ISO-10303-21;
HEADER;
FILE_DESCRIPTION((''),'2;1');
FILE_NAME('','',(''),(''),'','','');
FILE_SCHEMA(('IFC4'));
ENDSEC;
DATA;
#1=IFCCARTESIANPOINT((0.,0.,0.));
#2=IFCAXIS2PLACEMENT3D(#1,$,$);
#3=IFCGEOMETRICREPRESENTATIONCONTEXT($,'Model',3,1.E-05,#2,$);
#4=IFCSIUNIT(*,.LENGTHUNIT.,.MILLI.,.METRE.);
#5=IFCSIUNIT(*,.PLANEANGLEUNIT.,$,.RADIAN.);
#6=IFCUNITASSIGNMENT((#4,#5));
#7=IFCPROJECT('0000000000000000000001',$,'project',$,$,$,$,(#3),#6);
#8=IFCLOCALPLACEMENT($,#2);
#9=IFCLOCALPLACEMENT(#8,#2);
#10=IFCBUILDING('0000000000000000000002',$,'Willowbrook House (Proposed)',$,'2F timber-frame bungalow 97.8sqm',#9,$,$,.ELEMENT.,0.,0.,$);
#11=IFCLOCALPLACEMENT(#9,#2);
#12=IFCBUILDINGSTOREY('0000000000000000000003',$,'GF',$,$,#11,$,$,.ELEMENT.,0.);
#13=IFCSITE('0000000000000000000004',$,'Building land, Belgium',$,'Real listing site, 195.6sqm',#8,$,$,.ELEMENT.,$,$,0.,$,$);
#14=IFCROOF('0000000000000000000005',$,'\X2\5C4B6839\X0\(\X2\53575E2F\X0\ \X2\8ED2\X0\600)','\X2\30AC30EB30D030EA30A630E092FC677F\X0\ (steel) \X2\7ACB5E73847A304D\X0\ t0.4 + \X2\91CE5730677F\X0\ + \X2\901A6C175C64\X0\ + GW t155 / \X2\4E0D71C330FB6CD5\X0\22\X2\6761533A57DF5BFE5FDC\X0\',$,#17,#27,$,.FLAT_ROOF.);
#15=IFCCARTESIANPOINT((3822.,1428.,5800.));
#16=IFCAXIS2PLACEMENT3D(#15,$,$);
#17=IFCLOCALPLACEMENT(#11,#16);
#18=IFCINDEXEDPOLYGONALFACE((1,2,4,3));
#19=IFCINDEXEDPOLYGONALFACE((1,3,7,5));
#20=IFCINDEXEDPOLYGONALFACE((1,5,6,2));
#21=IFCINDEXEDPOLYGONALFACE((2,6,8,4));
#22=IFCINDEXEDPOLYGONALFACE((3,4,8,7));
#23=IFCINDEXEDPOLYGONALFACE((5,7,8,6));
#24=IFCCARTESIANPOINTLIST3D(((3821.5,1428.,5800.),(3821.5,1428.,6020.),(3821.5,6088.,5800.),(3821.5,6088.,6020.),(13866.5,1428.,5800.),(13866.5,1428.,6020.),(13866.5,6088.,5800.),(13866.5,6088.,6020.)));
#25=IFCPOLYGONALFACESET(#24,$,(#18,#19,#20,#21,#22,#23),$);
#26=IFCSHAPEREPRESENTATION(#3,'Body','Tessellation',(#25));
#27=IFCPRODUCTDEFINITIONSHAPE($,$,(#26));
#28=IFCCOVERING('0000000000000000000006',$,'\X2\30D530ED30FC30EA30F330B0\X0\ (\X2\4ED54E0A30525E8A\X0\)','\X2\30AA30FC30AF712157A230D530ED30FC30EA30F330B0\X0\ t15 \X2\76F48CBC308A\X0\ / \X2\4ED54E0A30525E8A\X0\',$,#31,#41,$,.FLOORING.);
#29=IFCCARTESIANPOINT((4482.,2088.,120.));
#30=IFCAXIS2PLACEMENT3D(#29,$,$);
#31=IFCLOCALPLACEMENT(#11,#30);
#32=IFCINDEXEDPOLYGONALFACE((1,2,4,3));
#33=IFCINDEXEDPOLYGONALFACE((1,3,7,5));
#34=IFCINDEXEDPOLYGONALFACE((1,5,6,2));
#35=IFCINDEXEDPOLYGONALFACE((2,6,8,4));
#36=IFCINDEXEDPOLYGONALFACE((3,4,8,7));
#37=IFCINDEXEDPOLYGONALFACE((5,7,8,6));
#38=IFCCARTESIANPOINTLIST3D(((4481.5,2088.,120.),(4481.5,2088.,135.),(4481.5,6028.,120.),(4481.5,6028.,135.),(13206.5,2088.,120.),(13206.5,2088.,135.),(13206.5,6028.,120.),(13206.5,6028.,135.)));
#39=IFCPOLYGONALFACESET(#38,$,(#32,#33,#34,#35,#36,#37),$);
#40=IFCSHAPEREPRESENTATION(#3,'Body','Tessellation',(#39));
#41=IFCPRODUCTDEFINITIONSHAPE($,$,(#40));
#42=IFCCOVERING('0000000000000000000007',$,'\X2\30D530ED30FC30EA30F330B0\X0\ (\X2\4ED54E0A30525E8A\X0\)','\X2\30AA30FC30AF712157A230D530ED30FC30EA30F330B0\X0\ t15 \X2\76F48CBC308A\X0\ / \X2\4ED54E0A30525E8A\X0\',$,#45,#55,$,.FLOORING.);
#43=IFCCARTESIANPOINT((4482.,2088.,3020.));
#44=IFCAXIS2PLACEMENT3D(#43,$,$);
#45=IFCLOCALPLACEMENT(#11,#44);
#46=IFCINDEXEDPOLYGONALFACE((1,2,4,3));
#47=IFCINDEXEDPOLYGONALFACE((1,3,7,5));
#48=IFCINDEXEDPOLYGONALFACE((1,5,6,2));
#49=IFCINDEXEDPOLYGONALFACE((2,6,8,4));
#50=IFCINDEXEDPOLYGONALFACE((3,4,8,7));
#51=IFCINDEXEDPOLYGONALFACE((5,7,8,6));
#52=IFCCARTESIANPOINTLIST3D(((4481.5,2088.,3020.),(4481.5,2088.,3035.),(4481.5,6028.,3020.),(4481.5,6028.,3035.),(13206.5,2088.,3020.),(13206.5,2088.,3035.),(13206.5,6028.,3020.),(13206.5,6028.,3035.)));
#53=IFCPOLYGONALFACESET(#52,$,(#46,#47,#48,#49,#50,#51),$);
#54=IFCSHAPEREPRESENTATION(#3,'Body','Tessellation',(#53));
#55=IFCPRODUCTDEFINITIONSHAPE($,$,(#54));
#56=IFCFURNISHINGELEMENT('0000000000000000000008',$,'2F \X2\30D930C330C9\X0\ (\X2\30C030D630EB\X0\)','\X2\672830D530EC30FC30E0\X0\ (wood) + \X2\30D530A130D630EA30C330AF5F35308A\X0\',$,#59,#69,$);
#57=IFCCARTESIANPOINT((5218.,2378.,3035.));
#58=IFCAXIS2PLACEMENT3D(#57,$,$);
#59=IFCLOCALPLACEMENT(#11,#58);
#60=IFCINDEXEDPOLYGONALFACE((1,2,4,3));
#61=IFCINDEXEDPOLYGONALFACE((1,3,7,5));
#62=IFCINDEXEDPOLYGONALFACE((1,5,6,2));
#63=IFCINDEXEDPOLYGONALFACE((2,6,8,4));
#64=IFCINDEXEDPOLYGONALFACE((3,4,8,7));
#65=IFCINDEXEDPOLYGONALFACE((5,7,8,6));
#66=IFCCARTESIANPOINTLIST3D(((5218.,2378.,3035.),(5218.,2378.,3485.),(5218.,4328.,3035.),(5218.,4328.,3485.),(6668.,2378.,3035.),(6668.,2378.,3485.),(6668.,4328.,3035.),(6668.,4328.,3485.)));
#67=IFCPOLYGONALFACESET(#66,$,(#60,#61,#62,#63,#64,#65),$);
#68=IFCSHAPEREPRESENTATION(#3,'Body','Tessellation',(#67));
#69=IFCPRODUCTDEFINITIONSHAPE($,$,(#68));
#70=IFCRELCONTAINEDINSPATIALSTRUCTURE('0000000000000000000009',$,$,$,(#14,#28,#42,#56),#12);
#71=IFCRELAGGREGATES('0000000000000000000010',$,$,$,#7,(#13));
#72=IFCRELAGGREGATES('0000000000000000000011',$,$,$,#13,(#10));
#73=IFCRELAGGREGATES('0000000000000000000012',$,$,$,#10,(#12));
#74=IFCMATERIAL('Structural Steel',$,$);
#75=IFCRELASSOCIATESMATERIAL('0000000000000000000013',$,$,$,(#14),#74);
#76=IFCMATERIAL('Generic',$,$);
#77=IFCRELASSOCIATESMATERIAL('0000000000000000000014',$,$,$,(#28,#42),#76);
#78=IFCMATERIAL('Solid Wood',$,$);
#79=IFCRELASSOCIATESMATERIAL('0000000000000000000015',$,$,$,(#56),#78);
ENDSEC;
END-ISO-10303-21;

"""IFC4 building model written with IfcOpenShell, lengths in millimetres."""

from ifc_helpers import new_model, si_unit, frame, frame_2d, origin, place, context, project, spatial, rectangle, extrude, material, element, save


model = new_model("IFC4")

# Units and contexts
model_context = context("Model", 3, precision=1e-05, world=origin())
ifc_project = project(units=[si_unit("LENGTHUNIT", "METRE", prefix="MILLI"), si_unit("PLANEANGLEUNIT", "RADIAN")], contexts=[model_context])

# Site, building, storey
site_placement = place(None, origin())
site = spatial("IfcSite", under=ifc_project, at=site_placement, Name="Building land, Belgium", ObjectType="Real listing site, 195.6sqm", CompositionType="ELEMENT", RefElevation=0.0)
building_placement = place(site_placement, origin())
building = spatial("IfcBuilding", under=site, at=building_placement, Name="Willowbrook House (Proposed)", ObjectType="2F timber-frame bungalow 97.8sqm", CompositionType="ELEMENT", ElevationOfRefHeight=0.0, ElevationOfTerrain=0.0)
storey_placement = place(building_placement, origin())
storey = spatial("IfcBuildingStorey", under=building, at=storey_placement, Name="GF", CompositionType="ELEMENT", Elevation=0.0)

# Shared definitions
ifc_material_1 = material(Name="Solid Wood")

# Roof
ifc_material_2 = material(Name="Structural Steel")
for number, where, name in (
    (1, (3822.0, 1428.0, 5800.0), "屋根(南帯 軒600)"),
):
    element("IfcRoof", number, at=place(storey_placement, frame(where)), inside=storey, material=ifc_material_2, Name=name, Description="ガルバリウム鋼板 (steel) 立平葺き t0.4 + 野地板 + 通気層 + GW t155 / 不燃・法22条区域対応", PredefinedType="FLAT_ROOF", context=model_context, shape_type="SweptSolid", body=[
        extrude(rectangle(XDim=10045.0, YDim=4660.0, at=frame_2d((5022.0, 2330.0))), frame((3822.0, 1428.0, 5800.0)), (0.0, 0.0, 1.0), 220.0),
    ])

# Coverings
ifc_material_3 = material(Name="Generic")
covering_1_placement = place(storey_placement, frame((4482.0, 2088.0, 120.0)))
element("IfcCovering", 2, at=covering_1_placement, inside=storey, material=ifc_material_3, Name="フローリング (仕上げ床)", Description="オーク無垢フローリング t15 直貼り / 仕上げ床", PredefinedType="FLOORING", context=model_context, shape_type="SweptSolid", body=[
    extrude(rectangle(XDim=8725.0, YDim=3940.0, at=frame_2d((4362.0, 1970.0))), frame((4482.0, 2088.0, 120.0)), (0.0, 0.0, 1.0), 15.0),
])
covering_2_placement = place(storey_placement, frame((4482.0, 2088.0, 3020.0)))
element("IfcCovering", 3, at=covering_2_placement, inside=storey, material=ifc_material_3, Name="フローリング (仕上げ床)", Description="オーク無垢フローリング t15 直貼り / 仕上げ床", PredefinedType="FLOORING", context=model_context, shape_type="SweptSolid", body=[
    extrude(rectangle(XDim=8725.0, YDim=3940.0, at=frame_2d((4362.0, 1970.0))), frame((4482.0, 2088.0, 3020.0)), (0.0, 0.0, 1.0), 15.0),
])

# Furnishing element
furnishing_placement = place(storey_placement, frame((5218.0, 2378.0, 3035.0)))
element("IfcFurnishingElement", 4, at=furnishing_placement, inside=storey, material=ifc_material_1, Name="2F ベッド (ダブル)", Description="木フレーム (wood) + ファブリック張り", context=model_context, shape_type="SweptSolid", body=[
    extrude(rectangle(XDim=1450.0, YDim=1950.0, at=frame_2d((725.0, 975.0))), frame((5218.0, 2378.0, 3035.0)), (0.0, 0.0, 1.0), 450.0),
])

save(model, "model.ifc")
